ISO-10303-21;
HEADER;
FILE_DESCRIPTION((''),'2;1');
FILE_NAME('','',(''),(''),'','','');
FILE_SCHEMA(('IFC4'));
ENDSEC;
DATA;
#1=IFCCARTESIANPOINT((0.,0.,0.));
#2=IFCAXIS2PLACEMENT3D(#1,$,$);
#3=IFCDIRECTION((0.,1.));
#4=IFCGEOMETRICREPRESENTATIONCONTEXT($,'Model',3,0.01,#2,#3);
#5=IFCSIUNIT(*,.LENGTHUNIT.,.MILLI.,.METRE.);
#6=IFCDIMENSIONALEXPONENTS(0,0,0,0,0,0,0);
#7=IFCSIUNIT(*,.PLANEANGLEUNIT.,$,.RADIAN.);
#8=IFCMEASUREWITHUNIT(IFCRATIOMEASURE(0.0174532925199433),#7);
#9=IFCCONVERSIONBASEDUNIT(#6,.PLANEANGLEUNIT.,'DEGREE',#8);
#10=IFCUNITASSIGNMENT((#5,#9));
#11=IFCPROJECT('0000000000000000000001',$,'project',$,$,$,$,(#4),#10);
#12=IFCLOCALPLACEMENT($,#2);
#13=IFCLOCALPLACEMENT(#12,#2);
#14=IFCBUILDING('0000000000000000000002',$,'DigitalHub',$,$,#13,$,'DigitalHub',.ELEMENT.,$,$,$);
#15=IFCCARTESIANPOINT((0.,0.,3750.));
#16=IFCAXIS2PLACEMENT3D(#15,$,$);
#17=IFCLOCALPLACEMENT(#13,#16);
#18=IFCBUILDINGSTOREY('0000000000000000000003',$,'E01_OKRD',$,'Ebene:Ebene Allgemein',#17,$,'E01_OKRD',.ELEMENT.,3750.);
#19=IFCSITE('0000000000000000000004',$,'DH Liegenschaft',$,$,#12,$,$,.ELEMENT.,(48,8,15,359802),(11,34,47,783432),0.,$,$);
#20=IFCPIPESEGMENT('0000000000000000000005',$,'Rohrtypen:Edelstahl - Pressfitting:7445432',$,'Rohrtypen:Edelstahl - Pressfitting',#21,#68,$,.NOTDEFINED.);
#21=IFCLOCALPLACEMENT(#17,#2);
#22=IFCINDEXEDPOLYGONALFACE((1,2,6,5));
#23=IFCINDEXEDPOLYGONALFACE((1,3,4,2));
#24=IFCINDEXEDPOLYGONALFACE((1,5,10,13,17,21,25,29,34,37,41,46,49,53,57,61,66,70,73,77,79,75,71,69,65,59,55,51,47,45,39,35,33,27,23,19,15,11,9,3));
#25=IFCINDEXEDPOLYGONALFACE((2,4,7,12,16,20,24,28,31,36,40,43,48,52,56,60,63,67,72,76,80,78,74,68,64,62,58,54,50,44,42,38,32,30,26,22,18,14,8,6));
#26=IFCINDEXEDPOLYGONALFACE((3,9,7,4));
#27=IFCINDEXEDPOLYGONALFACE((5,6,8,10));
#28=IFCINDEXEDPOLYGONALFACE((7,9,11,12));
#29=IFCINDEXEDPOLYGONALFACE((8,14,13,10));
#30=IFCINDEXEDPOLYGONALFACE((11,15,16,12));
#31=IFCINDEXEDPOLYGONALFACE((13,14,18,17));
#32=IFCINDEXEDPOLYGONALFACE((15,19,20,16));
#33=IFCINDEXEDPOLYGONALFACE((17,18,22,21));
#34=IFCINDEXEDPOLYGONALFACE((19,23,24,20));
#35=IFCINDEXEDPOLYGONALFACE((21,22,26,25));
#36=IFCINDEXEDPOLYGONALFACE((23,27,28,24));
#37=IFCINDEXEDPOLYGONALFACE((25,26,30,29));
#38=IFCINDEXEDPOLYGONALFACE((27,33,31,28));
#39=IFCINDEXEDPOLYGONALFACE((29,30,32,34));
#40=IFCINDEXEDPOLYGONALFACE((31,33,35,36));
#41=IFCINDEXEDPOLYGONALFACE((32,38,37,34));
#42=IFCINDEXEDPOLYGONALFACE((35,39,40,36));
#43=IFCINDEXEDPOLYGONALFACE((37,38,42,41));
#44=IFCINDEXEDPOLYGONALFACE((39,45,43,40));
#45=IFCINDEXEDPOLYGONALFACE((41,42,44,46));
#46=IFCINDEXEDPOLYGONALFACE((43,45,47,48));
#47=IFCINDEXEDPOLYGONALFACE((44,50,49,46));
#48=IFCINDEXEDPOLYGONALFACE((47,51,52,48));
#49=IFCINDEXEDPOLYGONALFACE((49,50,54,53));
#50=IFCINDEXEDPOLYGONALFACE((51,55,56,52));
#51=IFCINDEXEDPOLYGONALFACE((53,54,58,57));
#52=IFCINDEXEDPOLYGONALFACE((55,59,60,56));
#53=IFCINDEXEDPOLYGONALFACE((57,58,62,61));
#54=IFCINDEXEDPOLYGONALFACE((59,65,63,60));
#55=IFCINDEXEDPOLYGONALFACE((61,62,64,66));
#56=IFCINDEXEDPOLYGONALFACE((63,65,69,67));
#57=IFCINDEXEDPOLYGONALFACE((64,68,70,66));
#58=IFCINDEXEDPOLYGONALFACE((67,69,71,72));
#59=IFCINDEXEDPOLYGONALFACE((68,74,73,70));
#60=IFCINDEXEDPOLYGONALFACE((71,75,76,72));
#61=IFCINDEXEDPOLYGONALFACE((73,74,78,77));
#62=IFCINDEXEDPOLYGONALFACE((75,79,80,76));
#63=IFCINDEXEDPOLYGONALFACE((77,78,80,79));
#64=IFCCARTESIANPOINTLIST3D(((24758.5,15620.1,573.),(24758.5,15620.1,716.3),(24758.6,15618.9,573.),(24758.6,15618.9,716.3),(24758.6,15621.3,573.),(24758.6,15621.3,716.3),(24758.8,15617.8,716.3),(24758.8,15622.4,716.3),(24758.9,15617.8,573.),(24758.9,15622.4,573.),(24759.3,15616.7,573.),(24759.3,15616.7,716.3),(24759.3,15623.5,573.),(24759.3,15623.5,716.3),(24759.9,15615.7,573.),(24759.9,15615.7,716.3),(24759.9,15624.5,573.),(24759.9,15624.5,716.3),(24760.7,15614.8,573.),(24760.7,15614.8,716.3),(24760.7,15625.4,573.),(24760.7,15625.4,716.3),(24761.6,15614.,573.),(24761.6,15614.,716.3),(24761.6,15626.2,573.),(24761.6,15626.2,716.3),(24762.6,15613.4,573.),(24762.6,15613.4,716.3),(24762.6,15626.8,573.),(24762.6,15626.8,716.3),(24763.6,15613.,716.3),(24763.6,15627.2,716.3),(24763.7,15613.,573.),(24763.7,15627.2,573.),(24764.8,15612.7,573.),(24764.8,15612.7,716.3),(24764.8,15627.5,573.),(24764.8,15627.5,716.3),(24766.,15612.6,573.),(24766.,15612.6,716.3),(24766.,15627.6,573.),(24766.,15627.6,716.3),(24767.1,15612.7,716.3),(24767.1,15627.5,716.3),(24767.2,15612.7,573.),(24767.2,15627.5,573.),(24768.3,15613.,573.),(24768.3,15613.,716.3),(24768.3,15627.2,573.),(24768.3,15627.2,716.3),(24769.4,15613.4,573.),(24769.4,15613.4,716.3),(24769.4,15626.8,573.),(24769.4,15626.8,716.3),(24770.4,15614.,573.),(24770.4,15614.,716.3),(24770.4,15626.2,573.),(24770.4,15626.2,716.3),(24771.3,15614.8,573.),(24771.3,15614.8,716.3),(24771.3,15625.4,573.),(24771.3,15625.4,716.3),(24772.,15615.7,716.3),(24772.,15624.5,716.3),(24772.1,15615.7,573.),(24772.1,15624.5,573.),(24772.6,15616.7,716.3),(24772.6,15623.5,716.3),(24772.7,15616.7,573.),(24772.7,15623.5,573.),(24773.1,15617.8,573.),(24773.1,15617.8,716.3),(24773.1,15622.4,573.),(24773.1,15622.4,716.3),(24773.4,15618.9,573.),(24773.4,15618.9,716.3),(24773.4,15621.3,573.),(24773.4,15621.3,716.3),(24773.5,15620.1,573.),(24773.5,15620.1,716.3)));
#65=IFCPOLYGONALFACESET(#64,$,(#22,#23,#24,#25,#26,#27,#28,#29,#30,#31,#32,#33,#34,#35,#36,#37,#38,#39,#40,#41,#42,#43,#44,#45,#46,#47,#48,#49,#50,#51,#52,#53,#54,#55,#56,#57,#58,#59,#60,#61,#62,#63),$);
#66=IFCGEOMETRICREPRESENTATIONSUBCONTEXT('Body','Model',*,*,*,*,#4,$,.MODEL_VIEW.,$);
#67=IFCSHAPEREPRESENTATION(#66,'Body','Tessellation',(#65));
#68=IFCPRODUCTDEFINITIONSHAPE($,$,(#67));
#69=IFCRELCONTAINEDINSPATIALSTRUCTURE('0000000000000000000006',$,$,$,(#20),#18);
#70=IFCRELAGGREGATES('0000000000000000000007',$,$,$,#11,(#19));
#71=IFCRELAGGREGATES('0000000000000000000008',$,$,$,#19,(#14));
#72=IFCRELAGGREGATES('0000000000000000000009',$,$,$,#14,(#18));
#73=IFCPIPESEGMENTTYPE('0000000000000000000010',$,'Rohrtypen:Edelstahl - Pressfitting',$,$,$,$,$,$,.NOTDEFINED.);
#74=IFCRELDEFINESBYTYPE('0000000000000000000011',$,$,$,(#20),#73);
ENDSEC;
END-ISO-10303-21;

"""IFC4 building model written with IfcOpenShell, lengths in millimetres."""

from ifc_helpers import new_model, entity, si_unit, converted_unit, direction, frame, origin, place, context, subcontext, project, spatial, indexed_curve, outline, extrude, type_object, element, save


model = new_model("IFC4")

# Units and contexts
model_context = context("Model", 3, precision=0.01, world=origin(), true_north=direction((0.0, 1.0)))
body_context = subcontext(model_context, "Body", "Model", "MODEL_VIEW")
ifc_project = project(units=[si_unit("LENGTHUNIT", "METRE", prefix="MILLI"), converted_unit("PLANEANGLEUNIT", "DEGREE", entity("IfcRatioMeasure", 0.0174532925199433), si_unit("PLANEANGLEUNIT", "RADIAN"), dimensions=[0, 0, 0, 0, 0, 0, 0])], contexts=[model_context])

# Site, building, storey
site_placement = place(None, origin())
site = spatial("IfcSite", under=ifc_project, at=site_placement, Name="DH Liegenschaft", CompositionType="ELEMENT", RefLatitude=(48, 8, 15, 359802), RefLongitude=(11, 34, 47, 783432), RefElevation=0.0)
building_placement = place(site_placement, origin())
building = spatial("IfcBuilding", under=site, at=building_placement, Name="DigitalHub", LongName="DigitalHub", CompositionType="ELEMENT")
storey_placement = place(building_placement, frame((0.0, 0.0, 3750.0)))
storey = spatial("IfcBuildingStorey", under=building, at=storey_placement, Name="E01_OKRD", ObjectType="Ebene:Ebene Allgemein", LongName="E01_OKRD", CompositionType="ELEMENT", Elevation=3750.0)

# Pipe segment
pipe_segment_type_1 = type_object("IfcPipeSegmentType", Name="Rohrtypen:Edelstahl - Pressfitting", PredefinedType="NOTDEFINED")
pipe_segment_1_placement = place(storey_placement, frame((24756.9, 15611.0, 573.0)))
element("IfcPipeSegment", 1, at=pipe_segment_1_placement, inside=storey, type_object=pipe_segment_type_1, Name="Rohrtypen:Edelstahl - Pressfitting:7445432", ObjectType="Rohrtypen:Edelstahl - Pressfitting", PredefinedType="NOTDEFINED", context=body_context, shape_type="SweptSolid", body=[
    extrude(outline(indexed_curve([(7.5, 0.0), (7.4, 1.2), (7.1, 2.3), (6.7, 3.4), (6.1, 4.4), (5.3, 5.3), (4.4, 6.1), (3.4, 6.7), (2.3, 7.1), (1.2, 7.4), (0.0, 7.5), (-1.2, 7.4), (-2.3, 7.1), (-3.4, 6.7), (-4.4, 6.1), (-5.3, 5.3), (-6.1, 4.4), (-6.7, 3.4), (-7.1, 2.3), (-7.4, 1.2), (-7.5, 0.0), (-7.4, -1.2), (-7.1, -2.3), (-6.7, -3.4), (-6.1, -4.4), (-5.3, -5.3), (-4.4, -6.1), (-3.4, -6.7), (-2.3, -7.1), (-1.2, -7.4), (0.0, -7.5), (1.2, -7.4), (2.3, -7.1), (3.4, -6.7), (4.4, -6.1), (5.3, -5.3), (6.1, -4.4), (6.7, -3.4), (7.1, -2.3), (7.4, -1.2), (7.5, 0.0)], self_intersect=False)), frame((9.1, 9.1, 0.0), z_axis=(-0.000181, 0.0, 1.0), x_axis=(1.0, 0.0, 0.000181)), (0.0, 0.0, 1.0), 143.3),
])

save(model, "model.ifc")
